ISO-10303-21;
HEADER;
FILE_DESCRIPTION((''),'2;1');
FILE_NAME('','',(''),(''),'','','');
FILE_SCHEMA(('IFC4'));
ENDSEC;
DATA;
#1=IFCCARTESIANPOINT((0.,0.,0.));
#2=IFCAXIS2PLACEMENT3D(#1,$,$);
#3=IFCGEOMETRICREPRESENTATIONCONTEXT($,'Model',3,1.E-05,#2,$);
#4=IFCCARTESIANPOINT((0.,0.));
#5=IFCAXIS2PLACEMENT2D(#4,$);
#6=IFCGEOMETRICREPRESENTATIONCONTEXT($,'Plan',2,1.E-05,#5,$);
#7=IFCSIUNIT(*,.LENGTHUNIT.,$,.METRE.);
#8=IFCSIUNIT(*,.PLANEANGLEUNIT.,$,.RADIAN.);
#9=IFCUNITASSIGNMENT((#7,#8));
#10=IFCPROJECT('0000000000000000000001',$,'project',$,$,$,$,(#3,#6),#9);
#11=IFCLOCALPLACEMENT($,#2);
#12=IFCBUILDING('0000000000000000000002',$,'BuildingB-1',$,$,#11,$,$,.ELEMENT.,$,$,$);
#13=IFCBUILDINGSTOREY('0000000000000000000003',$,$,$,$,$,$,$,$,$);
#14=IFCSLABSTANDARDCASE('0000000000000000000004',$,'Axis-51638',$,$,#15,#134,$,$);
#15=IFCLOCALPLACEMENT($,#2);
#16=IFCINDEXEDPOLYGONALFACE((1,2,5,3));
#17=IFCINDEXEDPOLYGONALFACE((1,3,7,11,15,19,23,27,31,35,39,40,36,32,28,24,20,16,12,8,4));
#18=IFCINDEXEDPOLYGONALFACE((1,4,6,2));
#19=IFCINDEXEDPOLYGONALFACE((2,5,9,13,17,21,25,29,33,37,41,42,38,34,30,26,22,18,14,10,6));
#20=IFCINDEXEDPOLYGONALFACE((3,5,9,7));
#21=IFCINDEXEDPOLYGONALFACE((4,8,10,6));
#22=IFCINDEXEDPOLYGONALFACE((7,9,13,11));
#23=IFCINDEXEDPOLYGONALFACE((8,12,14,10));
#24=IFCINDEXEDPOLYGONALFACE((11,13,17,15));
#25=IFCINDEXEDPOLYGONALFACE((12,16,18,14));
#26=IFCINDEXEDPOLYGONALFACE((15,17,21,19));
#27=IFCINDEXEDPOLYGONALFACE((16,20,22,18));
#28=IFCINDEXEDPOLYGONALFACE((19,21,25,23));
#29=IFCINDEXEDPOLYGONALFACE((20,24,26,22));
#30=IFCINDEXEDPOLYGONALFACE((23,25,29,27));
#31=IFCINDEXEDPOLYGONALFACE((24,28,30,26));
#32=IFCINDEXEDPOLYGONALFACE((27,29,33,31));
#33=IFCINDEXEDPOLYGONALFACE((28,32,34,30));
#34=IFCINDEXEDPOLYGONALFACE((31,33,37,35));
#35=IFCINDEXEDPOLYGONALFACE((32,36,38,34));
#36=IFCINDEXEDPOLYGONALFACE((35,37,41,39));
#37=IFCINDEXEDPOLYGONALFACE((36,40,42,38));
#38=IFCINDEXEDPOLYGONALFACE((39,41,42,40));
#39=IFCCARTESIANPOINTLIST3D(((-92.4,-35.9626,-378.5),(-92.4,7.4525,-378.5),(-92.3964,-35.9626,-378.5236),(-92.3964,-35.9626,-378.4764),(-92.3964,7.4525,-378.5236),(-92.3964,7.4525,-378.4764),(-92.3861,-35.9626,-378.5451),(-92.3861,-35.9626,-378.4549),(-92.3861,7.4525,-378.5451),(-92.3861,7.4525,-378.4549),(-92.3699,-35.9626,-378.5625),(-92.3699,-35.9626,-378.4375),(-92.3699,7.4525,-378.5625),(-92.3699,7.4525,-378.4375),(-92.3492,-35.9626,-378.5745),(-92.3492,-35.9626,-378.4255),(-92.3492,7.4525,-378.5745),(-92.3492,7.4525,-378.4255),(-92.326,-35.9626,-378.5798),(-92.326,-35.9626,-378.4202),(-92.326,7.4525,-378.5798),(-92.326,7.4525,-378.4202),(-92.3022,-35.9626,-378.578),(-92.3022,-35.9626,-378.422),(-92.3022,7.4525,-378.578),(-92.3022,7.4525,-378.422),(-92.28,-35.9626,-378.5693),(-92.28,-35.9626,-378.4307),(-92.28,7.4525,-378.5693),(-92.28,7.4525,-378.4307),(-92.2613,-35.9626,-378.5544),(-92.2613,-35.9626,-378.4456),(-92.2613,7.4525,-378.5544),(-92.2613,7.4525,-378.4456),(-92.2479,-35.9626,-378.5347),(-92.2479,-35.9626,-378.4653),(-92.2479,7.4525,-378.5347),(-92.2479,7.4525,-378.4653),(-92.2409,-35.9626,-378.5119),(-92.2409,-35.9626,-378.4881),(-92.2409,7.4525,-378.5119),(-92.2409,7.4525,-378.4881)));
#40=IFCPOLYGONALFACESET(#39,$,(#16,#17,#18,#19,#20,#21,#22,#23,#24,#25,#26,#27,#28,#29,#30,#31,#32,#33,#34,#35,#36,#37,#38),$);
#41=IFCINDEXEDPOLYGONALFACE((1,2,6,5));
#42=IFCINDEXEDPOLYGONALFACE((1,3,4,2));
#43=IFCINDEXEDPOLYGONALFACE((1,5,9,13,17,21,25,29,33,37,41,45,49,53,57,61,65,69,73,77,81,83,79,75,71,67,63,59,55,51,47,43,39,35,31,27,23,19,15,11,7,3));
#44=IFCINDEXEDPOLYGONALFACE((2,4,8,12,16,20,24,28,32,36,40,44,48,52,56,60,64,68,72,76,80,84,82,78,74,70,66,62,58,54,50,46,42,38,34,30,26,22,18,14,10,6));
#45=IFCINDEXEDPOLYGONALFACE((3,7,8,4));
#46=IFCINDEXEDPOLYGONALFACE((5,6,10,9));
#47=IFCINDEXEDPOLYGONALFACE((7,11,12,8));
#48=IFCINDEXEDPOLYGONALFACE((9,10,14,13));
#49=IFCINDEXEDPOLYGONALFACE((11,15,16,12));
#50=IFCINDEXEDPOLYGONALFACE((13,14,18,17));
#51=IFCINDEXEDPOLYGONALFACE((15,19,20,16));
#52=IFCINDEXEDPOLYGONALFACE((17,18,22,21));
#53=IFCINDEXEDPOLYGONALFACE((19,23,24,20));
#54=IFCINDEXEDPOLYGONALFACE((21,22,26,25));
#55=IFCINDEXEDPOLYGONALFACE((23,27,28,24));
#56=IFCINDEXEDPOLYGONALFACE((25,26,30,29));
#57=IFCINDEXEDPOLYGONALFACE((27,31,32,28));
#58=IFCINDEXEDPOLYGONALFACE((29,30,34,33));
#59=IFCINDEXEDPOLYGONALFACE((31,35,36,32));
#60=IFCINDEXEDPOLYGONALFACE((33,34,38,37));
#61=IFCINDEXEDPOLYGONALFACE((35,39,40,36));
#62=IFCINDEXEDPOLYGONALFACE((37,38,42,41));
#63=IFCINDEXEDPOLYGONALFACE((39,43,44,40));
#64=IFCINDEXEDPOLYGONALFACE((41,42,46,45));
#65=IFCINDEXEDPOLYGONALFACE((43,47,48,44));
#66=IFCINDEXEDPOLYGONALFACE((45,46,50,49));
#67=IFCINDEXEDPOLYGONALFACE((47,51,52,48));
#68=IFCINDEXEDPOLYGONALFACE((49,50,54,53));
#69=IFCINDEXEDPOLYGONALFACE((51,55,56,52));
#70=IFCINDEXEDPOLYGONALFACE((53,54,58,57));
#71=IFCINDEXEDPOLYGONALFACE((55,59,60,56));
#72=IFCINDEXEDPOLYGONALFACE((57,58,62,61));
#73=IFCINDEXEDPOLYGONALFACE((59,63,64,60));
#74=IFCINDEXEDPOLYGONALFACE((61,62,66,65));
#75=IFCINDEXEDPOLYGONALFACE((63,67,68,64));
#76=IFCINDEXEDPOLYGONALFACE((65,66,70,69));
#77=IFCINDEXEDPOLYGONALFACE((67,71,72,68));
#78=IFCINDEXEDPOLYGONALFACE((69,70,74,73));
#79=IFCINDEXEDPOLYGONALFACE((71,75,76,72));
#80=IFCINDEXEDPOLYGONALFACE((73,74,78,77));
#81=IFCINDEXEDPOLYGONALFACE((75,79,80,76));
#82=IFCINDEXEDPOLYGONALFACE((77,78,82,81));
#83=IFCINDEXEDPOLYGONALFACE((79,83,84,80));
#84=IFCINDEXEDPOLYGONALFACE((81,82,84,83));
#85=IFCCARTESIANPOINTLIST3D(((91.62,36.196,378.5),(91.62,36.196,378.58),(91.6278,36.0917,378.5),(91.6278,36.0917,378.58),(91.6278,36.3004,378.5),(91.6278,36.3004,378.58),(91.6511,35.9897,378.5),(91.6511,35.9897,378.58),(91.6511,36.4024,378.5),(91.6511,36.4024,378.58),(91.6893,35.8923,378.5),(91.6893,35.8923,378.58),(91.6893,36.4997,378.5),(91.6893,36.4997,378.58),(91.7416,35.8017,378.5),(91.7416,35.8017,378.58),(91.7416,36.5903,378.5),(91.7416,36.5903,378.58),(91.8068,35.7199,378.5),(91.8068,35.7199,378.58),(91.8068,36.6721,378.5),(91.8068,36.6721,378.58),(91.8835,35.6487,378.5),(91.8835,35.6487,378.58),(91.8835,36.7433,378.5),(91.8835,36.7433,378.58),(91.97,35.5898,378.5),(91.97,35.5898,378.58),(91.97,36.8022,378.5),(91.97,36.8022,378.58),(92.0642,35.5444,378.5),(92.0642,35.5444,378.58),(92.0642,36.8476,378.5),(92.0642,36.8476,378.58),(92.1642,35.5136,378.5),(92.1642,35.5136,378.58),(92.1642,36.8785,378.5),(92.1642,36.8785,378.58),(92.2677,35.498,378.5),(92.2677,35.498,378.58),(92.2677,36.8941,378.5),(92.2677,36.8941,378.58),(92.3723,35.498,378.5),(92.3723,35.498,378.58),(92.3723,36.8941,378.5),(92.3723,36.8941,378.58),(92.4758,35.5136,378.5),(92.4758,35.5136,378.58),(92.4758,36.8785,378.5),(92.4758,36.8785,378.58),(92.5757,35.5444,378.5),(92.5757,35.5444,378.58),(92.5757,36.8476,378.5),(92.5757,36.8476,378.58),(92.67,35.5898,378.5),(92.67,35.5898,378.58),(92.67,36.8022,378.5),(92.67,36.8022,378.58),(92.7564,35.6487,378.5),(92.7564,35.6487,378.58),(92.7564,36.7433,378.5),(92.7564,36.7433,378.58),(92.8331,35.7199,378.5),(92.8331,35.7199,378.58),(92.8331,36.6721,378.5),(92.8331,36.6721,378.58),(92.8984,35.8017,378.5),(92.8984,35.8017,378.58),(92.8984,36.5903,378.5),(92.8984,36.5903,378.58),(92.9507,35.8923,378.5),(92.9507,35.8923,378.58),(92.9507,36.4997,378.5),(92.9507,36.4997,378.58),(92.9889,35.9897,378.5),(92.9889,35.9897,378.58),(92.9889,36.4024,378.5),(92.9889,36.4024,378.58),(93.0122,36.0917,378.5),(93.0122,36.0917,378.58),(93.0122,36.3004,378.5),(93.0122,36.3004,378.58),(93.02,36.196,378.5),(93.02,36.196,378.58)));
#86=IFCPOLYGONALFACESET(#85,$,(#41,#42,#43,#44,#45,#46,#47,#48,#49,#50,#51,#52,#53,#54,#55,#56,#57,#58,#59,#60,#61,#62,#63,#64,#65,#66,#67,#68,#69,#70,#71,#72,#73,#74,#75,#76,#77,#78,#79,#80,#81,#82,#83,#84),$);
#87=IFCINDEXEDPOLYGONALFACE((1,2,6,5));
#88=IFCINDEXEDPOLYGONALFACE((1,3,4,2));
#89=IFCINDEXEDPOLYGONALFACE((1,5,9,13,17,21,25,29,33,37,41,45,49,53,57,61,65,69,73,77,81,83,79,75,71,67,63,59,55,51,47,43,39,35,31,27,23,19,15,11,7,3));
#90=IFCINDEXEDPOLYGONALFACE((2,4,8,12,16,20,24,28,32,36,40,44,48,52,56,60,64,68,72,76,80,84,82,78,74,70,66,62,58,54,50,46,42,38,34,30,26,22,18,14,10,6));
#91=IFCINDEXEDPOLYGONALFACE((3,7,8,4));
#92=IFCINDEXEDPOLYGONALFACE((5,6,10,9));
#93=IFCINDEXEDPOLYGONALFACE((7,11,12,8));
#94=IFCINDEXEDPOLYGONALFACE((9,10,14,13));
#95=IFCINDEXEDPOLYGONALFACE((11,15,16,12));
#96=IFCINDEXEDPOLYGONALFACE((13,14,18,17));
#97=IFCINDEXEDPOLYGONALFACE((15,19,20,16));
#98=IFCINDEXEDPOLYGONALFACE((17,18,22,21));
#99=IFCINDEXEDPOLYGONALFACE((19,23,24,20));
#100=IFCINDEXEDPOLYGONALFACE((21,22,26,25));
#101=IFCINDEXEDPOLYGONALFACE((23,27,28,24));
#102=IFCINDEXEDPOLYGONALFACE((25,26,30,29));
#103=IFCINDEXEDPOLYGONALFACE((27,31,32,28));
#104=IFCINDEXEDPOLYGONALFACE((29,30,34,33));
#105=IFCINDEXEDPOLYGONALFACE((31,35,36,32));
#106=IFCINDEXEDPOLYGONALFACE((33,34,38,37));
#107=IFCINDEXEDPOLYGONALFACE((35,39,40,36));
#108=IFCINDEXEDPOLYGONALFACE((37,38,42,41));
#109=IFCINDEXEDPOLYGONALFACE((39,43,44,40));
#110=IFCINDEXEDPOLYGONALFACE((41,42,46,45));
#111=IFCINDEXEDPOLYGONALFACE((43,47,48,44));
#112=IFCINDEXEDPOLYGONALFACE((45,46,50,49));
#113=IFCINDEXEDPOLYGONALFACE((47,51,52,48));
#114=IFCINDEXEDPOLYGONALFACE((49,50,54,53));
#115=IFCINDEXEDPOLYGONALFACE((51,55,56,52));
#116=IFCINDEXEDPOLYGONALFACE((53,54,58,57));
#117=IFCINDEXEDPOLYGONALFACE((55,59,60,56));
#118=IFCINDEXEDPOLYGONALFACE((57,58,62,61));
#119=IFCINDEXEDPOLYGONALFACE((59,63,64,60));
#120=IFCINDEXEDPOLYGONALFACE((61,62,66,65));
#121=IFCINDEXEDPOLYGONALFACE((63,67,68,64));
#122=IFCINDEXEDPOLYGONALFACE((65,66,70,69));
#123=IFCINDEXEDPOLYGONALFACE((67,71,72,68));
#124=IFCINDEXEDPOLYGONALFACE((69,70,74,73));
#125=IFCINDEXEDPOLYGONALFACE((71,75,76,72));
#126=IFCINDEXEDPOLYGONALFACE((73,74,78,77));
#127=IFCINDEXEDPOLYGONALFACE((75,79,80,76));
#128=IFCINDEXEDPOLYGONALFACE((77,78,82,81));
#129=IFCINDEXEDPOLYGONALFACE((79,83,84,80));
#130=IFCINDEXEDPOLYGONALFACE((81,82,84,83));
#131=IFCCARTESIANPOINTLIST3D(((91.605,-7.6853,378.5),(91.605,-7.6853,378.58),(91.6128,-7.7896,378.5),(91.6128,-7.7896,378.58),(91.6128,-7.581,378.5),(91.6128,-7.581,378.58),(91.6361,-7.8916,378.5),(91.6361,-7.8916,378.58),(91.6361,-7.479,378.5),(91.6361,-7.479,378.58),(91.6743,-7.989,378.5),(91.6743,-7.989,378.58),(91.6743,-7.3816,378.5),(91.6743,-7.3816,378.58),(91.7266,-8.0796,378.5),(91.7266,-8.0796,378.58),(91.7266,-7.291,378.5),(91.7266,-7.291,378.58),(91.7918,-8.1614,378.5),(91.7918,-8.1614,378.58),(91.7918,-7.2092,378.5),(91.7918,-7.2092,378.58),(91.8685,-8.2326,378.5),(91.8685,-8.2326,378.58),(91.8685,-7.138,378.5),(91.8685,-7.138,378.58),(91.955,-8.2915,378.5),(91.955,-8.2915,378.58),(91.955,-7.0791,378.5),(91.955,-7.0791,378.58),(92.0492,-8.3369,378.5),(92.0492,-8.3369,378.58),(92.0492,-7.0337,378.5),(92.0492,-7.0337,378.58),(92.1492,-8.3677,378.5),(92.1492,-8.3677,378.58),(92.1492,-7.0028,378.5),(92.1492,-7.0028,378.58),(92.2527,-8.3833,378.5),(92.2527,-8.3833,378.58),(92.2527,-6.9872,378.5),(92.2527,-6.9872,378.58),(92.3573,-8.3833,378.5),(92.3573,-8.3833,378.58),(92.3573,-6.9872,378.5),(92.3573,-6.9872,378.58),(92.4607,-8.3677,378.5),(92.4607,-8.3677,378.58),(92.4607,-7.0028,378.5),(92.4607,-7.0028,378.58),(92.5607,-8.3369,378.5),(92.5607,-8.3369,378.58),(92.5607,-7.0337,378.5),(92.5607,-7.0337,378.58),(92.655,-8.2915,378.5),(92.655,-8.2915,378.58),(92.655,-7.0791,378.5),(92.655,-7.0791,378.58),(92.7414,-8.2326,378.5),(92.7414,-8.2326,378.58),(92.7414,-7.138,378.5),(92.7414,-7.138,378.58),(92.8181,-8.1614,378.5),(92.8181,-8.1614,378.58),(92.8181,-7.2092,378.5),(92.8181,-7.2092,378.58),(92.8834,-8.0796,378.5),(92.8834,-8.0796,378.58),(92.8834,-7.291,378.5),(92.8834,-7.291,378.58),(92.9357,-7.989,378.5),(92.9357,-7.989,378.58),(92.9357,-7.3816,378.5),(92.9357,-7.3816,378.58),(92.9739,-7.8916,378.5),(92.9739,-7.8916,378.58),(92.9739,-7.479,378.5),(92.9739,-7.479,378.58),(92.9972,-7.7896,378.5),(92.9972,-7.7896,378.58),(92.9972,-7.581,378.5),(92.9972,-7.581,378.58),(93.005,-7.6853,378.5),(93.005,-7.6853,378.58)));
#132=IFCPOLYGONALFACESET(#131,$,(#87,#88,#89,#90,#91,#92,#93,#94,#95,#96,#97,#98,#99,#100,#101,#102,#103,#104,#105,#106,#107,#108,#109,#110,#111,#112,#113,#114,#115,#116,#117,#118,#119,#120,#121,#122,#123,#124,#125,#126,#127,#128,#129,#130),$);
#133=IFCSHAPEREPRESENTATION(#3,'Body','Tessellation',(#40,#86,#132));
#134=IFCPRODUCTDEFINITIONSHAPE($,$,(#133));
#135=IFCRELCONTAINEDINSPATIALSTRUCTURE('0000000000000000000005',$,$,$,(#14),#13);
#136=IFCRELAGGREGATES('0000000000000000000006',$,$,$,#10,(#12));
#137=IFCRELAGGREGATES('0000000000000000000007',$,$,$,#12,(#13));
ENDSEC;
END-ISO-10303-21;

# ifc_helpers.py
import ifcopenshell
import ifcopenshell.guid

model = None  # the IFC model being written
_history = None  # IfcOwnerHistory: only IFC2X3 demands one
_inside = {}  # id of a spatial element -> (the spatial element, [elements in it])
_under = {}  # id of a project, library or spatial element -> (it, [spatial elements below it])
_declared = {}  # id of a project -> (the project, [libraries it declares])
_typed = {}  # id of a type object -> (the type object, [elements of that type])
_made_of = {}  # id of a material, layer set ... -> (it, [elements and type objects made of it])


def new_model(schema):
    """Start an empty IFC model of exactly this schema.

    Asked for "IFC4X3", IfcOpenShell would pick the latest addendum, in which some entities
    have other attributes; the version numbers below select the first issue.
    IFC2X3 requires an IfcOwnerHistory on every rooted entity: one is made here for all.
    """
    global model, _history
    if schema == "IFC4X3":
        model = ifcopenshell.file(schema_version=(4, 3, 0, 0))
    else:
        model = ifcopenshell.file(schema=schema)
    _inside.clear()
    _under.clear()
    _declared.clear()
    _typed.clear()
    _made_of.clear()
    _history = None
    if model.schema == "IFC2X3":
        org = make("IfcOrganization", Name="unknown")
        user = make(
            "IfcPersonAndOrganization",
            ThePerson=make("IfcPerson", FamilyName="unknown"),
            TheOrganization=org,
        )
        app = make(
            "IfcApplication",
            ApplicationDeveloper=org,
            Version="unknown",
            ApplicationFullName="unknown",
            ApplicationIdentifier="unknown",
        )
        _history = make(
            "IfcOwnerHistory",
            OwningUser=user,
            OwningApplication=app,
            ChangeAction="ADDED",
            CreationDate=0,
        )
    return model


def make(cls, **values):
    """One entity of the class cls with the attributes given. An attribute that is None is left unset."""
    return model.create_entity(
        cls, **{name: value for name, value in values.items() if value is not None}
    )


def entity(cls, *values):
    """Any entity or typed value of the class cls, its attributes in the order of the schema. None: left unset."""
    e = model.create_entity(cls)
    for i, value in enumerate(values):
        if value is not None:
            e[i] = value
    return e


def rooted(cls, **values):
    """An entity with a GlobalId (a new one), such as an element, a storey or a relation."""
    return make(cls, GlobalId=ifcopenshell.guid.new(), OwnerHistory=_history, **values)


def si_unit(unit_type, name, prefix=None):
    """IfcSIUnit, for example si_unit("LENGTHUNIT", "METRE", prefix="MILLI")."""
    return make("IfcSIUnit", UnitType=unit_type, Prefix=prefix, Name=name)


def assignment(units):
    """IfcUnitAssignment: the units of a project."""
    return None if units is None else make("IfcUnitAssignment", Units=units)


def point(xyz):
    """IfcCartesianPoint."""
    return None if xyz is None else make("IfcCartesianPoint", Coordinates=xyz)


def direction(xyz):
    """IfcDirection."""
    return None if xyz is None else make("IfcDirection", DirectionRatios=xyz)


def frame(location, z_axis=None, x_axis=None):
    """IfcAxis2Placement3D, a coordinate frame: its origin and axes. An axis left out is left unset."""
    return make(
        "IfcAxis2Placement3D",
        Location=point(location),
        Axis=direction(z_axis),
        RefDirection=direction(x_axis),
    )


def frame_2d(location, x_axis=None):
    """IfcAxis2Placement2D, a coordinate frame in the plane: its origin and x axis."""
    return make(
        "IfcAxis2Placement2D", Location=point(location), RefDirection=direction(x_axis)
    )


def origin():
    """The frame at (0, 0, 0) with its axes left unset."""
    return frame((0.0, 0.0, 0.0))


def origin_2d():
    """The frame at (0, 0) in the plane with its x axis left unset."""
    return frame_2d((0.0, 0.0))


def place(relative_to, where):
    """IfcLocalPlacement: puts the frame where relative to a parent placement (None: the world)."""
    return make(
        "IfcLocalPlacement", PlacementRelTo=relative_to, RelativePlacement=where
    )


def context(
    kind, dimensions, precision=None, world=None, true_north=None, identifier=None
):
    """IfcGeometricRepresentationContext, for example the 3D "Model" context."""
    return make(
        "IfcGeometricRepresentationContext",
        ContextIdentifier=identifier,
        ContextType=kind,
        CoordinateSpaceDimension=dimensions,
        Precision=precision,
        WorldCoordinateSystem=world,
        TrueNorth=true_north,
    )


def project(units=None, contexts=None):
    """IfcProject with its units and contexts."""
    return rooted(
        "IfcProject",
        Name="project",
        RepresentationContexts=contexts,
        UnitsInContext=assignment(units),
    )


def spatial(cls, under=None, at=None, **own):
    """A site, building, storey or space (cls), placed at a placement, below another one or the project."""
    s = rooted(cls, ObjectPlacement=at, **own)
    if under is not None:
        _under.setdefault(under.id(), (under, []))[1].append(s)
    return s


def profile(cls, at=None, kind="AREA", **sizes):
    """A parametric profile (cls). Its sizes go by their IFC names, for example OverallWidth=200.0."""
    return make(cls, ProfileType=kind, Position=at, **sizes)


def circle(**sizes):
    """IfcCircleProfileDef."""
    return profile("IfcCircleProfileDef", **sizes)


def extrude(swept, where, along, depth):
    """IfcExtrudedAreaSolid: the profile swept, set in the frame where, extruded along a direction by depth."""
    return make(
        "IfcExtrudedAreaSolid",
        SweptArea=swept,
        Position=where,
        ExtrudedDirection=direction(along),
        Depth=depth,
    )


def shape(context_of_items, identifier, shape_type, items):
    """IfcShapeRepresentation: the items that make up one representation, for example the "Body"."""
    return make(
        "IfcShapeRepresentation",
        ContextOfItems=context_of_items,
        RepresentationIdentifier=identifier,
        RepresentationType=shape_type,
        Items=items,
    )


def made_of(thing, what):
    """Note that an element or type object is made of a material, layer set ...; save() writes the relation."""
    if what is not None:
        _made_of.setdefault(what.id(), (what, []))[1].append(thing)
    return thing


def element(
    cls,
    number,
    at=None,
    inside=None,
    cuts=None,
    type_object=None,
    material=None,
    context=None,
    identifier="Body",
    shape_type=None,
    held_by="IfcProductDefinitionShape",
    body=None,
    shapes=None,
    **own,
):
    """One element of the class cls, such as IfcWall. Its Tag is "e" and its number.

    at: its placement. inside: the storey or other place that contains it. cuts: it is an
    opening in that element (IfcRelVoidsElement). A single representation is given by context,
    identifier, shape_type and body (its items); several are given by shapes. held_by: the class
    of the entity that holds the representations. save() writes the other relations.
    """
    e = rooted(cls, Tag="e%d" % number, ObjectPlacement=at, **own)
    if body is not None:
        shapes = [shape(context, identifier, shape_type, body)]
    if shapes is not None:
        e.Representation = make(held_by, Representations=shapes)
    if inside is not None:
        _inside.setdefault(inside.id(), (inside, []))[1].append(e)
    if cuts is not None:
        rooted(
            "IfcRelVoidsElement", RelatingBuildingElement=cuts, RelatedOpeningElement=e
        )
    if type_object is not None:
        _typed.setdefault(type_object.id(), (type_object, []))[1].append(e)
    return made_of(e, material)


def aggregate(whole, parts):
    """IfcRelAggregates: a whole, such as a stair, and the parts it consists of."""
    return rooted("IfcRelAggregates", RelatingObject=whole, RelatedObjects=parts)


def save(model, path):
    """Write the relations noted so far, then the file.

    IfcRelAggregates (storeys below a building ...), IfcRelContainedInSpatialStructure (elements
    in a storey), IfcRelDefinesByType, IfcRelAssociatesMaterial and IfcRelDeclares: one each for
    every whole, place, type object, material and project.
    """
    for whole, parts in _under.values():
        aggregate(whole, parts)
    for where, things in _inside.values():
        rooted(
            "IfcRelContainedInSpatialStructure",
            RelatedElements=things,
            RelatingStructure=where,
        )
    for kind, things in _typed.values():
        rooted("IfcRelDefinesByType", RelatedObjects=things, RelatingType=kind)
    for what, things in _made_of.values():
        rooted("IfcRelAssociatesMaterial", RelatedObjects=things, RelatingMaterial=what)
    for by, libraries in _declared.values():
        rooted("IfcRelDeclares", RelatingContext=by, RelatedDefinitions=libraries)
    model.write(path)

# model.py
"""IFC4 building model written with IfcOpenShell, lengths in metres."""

from ifc_helpers import new_model, entity, si_unit, frame, origin, origin_2d, place, context, project, spatial, circle, extrude, element, save


model = new_model("IFC4")

# Units and contexts
model_context = context("Model", 3, precision=1e-05, world=origin())
plan_context = context("Plan", 2, precision=1e-05, world=origin_2d())
ifc_project = project(units=[si_unit("LENGTHUNIT", "METRE"), si_unit("PLANEANGLEUNIT", "RADIAN")], contexts=[model_context, plan_context])

# Building, storey
building_placement = place(None, origin())
building = spatial("IfcBuilding", under=ifc_project, at=building_placement, Name="BuildingB-1", CompositionType="ELEMENT")
storey = spatial("IfcBuildingStorey", under=building)

# Slab
element("IfcSlabStandardCase", 1, inside=storey, Name="Axis-51638", context=model_context, shape_type="AdvancedSweptSolid", body=[
    entity("IfcSurfaceCurveSweptAreaSolid", entity("IfcCircleProfileDef", "AREA", None, None, 0.08), None, entity("IfcPolyline", [entity("IfcCartesianPoint", [92.32, 35.9626, 378.5]), entity("IfcCartesianPoint", [92.32, -7.4525, 378.5])]), None, None, entity("IfcPlane", entity("IfcAxis2Placement3D", entity("IfcCartesianPoint", [92.32, 35.9626, 378.5]), entity("IfcDirection", [0.0, 0.0, 1.0]), entity("IfcDirection", [1.0, 0.0, 0.0])))),
    extrude(circle(Radius=0.7), frame((92.32, 36.196, 378.5)), (0.0, 0.0, 1.0), 0.08),
    extrude(circle(Radius=0.7), frame((92.305, -7.6853, 378.5)), (0.0, 0.0, 1.0), 0.08),
])

save(model, "model.ifc")
